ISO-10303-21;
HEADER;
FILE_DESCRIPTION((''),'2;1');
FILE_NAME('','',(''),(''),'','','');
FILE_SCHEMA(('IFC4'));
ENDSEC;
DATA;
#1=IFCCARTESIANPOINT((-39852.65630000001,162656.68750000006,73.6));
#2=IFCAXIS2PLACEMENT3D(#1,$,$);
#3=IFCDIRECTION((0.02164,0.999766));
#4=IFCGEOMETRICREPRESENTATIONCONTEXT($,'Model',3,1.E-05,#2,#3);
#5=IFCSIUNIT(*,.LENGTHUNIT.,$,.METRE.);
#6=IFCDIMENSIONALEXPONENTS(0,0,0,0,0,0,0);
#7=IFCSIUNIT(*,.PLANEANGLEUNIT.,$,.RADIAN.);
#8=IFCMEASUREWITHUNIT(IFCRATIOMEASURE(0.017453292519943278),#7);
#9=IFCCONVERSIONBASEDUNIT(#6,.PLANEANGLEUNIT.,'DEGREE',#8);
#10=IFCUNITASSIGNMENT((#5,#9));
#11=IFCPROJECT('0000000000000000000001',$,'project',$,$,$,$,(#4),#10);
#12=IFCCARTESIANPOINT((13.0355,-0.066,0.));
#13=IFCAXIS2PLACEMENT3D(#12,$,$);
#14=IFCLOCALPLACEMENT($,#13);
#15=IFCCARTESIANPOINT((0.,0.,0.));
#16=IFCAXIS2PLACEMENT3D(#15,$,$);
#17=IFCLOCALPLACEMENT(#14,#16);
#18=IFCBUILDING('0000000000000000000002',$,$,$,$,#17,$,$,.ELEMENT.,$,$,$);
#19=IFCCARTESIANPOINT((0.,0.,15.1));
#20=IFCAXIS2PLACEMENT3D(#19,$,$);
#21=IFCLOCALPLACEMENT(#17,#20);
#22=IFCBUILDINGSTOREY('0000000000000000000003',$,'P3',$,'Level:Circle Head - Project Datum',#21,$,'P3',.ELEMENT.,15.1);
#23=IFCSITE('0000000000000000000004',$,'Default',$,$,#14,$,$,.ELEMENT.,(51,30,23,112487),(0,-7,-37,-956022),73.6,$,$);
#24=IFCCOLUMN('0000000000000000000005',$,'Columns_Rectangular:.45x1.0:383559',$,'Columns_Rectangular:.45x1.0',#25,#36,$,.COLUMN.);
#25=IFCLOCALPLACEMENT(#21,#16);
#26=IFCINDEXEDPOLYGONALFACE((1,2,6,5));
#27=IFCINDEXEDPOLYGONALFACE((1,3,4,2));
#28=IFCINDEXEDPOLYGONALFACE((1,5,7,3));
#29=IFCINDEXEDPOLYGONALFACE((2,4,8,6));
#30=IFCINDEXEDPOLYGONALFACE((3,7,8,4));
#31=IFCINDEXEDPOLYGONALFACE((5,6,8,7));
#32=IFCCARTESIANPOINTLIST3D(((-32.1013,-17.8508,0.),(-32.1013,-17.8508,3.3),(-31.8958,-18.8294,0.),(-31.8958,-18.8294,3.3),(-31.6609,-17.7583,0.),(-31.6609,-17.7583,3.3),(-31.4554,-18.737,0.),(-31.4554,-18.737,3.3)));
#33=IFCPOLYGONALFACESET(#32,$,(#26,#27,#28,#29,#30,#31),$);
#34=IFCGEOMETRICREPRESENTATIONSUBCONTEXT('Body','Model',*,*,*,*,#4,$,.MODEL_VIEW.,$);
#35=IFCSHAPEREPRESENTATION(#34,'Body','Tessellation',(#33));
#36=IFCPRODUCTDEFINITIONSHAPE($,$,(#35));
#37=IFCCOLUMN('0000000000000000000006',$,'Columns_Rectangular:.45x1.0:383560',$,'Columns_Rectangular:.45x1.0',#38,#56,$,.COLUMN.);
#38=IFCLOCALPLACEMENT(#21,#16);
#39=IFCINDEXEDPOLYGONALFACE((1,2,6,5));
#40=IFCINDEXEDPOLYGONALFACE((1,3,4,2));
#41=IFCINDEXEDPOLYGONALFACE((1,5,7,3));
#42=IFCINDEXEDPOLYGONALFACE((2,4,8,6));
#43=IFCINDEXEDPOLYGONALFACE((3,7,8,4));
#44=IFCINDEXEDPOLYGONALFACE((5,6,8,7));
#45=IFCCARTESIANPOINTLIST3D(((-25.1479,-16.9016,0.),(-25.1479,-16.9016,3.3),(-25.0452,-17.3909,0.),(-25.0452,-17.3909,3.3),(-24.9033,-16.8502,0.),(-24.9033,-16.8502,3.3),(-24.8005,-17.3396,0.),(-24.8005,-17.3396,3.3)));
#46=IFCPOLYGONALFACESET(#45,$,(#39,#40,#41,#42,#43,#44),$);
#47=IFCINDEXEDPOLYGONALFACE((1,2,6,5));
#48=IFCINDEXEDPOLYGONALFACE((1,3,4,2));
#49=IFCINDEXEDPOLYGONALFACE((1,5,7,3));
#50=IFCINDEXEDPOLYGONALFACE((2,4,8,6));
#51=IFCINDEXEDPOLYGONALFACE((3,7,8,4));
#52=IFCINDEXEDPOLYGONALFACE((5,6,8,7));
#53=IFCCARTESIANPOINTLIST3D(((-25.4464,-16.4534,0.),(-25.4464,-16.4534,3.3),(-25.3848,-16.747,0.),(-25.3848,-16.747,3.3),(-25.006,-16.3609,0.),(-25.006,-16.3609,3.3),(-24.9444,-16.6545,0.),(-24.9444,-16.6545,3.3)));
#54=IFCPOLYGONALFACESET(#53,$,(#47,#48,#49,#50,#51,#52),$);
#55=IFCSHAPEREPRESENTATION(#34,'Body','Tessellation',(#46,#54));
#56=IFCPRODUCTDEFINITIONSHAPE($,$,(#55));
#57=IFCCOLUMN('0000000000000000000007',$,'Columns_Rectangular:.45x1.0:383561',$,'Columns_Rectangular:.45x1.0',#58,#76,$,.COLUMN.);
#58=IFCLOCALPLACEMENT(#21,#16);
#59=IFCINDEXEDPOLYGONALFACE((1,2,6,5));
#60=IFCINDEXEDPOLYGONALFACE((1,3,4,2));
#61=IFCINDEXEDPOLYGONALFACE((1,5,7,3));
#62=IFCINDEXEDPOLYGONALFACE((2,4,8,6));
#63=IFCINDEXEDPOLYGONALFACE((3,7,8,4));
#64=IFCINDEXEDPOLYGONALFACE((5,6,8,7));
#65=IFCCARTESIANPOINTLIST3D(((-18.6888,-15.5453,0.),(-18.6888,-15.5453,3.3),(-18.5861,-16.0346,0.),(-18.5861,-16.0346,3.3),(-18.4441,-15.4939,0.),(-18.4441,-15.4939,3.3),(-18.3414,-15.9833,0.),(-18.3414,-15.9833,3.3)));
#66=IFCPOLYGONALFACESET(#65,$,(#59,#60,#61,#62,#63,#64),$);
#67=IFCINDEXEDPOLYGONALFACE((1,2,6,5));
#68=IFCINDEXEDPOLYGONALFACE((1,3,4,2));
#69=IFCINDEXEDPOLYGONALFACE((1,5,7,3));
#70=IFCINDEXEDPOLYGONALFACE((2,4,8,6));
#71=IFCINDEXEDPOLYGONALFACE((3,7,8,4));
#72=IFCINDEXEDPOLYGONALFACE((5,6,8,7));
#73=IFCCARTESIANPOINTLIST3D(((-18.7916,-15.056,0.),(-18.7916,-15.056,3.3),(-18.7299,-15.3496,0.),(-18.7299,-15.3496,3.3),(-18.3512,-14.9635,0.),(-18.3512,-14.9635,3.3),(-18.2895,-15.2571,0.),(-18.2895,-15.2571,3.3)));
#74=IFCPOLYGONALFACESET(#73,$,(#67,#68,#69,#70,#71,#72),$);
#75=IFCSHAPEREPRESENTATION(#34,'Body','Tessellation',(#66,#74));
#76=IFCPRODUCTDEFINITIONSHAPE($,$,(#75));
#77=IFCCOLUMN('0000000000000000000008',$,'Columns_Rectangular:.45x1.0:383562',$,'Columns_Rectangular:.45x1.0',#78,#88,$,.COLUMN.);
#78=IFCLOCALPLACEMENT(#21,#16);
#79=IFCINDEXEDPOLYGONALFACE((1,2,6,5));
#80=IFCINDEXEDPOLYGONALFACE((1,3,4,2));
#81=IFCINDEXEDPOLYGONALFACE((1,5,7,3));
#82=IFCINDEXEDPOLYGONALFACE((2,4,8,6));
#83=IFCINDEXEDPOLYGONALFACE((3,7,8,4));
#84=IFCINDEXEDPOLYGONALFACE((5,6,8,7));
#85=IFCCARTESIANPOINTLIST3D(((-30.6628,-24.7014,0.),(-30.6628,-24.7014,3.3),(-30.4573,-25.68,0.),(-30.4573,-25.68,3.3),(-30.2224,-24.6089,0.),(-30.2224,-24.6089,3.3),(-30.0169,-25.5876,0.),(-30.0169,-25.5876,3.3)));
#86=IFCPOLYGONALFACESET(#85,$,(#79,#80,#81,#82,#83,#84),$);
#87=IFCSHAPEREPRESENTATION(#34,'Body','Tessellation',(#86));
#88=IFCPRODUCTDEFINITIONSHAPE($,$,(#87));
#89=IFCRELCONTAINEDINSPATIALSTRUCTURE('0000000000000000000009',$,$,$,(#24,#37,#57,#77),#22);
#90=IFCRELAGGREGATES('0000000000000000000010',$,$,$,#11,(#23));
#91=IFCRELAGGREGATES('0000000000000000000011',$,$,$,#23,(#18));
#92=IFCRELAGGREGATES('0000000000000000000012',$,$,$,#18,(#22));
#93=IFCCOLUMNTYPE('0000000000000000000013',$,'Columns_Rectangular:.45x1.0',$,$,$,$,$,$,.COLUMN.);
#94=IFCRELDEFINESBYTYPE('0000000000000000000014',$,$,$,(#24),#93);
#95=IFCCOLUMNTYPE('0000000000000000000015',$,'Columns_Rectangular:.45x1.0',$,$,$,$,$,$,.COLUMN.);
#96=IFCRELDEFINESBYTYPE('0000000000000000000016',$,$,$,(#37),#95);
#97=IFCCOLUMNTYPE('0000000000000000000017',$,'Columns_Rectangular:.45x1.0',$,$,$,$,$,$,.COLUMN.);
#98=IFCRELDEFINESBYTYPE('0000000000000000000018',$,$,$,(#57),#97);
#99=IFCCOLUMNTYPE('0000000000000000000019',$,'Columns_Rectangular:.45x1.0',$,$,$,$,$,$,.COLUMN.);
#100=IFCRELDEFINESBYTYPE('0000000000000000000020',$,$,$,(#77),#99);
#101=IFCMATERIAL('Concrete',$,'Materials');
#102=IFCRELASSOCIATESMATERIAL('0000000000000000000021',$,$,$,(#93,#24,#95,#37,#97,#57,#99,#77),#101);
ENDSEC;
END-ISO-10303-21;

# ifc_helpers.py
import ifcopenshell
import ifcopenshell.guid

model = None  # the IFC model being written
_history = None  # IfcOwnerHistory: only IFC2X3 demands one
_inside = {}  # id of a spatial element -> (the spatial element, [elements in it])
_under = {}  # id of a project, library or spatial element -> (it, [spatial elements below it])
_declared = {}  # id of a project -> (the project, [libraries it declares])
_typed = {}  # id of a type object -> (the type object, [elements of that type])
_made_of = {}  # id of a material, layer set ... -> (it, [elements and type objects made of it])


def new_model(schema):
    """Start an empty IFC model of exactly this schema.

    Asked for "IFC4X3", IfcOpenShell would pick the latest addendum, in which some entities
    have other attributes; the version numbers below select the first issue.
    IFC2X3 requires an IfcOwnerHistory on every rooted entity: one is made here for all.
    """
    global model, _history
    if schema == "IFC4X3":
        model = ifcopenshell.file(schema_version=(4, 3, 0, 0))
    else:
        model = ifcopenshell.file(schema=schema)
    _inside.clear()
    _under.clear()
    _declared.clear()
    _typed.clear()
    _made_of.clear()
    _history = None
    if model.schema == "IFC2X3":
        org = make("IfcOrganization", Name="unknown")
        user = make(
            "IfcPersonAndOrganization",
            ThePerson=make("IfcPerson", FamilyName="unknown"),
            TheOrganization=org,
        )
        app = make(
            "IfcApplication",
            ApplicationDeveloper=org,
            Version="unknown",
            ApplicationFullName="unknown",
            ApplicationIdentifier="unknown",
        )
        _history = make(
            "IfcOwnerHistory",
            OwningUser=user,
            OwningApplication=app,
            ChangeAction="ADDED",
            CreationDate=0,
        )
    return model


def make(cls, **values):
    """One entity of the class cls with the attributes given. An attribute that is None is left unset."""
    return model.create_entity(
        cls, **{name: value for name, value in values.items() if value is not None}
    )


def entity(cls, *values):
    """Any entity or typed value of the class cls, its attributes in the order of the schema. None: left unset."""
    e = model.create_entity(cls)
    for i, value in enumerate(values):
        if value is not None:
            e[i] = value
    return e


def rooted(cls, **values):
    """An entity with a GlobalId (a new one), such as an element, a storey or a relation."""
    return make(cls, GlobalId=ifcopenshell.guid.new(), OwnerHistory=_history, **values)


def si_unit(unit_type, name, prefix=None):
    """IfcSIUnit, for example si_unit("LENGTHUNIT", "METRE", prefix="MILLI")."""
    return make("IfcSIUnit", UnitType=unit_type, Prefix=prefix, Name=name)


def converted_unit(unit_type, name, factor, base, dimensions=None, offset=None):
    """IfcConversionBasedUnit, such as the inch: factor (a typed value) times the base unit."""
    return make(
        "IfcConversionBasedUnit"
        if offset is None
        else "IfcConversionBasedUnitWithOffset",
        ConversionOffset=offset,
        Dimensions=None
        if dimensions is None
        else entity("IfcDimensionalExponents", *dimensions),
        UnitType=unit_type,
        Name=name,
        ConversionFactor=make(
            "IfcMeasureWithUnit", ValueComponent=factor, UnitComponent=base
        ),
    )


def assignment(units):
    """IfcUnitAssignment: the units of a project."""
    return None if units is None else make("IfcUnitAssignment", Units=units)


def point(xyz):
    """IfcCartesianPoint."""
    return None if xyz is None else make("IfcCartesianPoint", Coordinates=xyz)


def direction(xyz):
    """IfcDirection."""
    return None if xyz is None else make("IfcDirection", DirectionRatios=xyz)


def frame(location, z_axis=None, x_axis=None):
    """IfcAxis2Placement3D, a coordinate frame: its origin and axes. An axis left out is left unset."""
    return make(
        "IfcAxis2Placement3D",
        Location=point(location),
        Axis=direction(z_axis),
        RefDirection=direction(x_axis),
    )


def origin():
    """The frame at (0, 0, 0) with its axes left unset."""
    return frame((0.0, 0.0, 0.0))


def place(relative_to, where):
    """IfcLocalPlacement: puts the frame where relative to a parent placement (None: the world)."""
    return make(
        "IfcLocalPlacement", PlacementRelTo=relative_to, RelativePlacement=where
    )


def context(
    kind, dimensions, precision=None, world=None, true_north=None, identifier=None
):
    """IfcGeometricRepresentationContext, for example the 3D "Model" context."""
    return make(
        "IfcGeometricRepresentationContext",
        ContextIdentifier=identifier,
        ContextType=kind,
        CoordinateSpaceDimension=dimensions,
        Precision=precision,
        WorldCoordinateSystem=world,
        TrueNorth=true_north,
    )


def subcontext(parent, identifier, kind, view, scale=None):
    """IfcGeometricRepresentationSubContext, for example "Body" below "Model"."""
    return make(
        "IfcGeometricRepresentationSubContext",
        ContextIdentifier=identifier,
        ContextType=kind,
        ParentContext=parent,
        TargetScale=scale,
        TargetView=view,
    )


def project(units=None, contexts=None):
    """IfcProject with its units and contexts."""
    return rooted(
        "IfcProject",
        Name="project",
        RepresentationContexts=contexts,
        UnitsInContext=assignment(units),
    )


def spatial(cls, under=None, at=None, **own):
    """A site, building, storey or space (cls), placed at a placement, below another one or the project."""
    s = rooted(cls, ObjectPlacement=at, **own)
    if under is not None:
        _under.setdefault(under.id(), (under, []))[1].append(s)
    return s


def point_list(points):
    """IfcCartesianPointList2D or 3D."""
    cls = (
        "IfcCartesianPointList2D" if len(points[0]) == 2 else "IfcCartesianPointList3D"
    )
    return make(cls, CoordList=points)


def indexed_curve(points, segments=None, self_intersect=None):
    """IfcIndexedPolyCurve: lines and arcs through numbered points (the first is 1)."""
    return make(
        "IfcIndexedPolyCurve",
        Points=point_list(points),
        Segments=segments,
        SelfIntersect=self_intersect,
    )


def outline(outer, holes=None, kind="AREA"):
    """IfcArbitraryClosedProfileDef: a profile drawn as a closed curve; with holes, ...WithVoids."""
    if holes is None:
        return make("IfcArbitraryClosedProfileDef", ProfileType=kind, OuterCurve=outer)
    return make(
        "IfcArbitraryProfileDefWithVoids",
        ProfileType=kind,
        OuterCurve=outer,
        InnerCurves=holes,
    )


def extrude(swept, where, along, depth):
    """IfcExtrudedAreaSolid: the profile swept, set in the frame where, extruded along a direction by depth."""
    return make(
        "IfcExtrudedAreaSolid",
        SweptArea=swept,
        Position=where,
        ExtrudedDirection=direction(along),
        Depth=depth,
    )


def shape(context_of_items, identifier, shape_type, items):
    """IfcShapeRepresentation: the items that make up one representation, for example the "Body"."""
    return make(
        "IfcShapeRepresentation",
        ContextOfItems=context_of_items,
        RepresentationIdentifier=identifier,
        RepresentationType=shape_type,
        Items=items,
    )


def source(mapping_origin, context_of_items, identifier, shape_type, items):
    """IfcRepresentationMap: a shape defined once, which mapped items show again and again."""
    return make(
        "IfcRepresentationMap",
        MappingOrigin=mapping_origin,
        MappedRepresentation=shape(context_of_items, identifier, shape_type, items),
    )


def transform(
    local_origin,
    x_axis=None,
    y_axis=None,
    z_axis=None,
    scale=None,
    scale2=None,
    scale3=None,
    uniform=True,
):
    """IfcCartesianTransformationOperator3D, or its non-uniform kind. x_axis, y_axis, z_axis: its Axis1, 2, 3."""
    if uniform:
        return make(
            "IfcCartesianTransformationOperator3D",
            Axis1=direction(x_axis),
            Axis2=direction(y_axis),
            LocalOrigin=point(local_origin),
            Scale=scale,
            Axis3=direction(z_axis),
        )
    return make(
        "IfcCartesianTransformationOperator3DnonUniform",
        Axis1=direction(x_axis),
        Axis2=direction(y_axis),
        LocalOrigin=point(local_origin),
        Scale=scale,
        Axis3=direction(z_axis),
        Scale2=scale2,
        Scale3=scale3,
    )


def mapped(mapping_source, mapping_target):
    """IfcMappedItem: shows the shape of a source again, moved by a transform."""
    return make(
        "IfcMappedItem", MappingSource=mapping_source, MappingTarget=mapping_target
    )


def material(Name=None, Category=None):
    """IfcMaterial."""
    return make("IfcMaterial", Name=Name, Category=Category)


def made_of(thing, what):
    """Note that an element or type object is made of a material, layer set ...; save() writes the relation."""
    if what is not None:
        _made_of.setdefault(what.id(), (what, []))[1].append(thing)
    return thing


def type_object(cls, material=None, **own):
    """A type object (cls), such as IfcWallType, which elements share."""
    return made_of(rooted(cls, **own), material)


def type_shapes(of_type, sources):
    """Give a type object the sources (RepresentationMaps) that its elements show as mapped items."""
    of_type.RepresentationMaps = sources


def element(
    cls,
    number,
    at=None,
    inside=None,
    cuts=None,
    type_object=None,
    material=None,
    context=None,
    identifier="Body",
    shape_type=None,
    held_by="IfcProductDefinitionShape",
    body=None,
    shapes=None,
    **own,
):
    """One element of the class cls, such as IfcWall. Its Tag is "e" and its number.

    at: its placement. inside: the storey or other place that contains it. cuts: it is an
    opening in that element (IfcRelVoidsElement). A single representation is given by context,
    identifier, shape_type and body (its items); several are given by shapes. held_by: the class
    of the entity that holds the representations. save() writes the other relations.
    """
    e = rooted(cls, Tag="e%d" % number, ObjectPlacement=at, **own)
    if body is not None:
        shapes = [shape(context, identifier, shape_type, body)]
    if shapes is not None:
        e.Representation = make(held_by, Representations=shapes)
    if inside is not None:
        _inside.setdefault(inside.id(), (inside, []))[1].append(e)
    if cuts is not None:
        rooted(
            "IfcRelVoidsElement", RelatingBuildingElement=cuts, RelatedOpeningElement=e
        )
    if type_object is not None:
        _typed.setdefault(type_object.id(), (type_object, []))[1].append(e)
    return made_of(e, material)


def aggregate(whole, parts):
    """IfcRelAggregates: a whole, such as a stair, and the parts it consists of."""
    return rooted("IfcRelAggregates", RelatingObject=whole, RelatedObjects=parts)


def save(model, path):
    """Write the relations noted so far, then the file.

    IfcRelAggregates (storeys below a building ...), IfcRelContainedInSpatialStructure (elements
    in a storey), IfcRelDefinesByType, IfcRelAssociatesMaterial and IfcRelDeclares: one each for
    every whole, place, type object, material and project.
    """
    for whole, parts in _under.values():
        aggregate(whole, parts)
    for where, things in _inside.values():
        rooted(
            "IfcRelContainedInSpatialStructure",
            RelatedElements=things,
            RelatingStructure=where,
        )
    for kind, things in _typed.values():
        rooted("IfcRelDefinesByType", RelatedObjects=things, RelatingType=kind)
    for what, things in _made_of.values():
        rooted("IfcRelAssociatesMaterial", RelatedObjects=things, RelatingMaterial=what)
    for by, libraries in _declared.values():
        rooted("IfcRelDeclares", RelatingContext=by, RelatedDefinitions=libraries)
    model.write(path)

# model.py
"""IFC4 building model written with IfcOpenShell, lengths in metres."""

from ifc_helpers import new_model, entity, si_unit, converted_unit, direction, frame, origin, place, context, subcontext, project, spatial, indexed_curve, outline, extrude, source, transform, mapped, material, type_object, type_shapes, element, save


model = new_model("IFC4")

# Units and contexts
model_context = context("Model", 3, precision=1e-05, world=frame((-39852.65630000001, 162656.68750000006, 73.6)), true_north=direction((0.02164, 0.999766)))
body_context = subcontext(model_context, "Body", "Model", "MODEL_VIEW")
ifc_project = project(units=[si_unit("LENGTHUNIT", "METRE"), converted_unit("PLANEANGLEUNIT", "DEGREE", entity("IfcRatioMeasure", 0.017453292519943278), si_unit("PLANEANGLEUNIT", "RADIAN"), dimensions=[0, 0, 0, 0, 0, 0, 0])], contexts=[model_context])

# Site, building, storey
site_placement = place(None, frame((13.0355, -0.066, 0.0)))
site = spatial("IfcSite", under=ifc_project, at=site_placement, Name="Default", CompositionType="ELEMENT", RefLatitude=(51, 30, 23, 112487), RefLongitude=(0, -7, -37, -956022), RefElevation=73.6)
building_placement = place(site_placement, origin())
building = spatial("IfcBuilding", under=site, at=building_placement, CompositionType="ELEMENT")
storey_placement = place(building_placement, frame((0.0, 0.0, 15.1)))
storey = spatial("IfcBuildingStorey", under=building, at=storey_placement, Name="P3", ObjectType="Level:Circle Head - Project Datum", LongName="P3", CompositionType="ELEMENT", Elevation=15.1)

# Columns
ifc_material = material(Name="Concrete", Category="Materials")
column_type_1 = type_object("IfcColumnType", Name="Columns_Rectangular:.45x1.0", PredefinedType="COLUMN", material=ifc_material)
shared_shape_1 = source(origin(), body_context, "Body", "SweptSolid", [
    extrude(outline(indexed_curve([(-0.5, -0.225), (0.5, -0.225), (0.5, 0.225), (-0.5, 0.225), (-0.5, -0.225)], self_intersect=False)), frame((-31.7784, -18.2939, 15.1), z_axis=(0.0, 0.0, 1.0), x_axis=(-0.2055, 0.978657, 0.0)), (0.0, 0.0, 1.0), 3.3),
])
type_shapes(column_type_1, [shared_shape_1])
column_1_placement = place(storey_placement, frame((0.0, 0.0, -15.1)))
element("IfcColumn", 1, at=column_1_placement, inside=storey, type_object=column_type_1, material=ifc_material, Name="Columns_Rectangular:.45x1.0:383559", ObjectType="Columns_Rectangular:.45x1.0", PredefinedType="COLUMN", context=body_context, shape_type="MappedRepresentation", body=[
    mapped(shared_shape_1, transform((0.0, 0.0, 0.0), scale=1.0)),
])
column_type_2 = type_object("IfcColumnType", Name="Columns_Rectangular:.45x1.0", PredefinedType="COLUMN", material=ifc_material)
shared_shape_2 = source(origin(), body_context, "Body", "SweptSolid", [
    extrude(outline(indexed_curve([(-0.25, -0.125), (0.25, -0.125), (0.25, 0.125), (-0.25, 0.125), (-0.25, -0.125)], self_intersect=False)), frame((-24.9742, -17.1206, 15.1), z_axis=(0.0, 0.0, 1.0), x_axis=(-0.2055, 0.978657, 0.0)), (0.0, 0.0, 1.0), 3.3),
    extrude(outline(indexed_curve([(-0.225, -0.15), (0.225, -0.15), (0.225, 0.15), (-0.225, 0.15), (-0.225, -0.15)], self_intersect=False)), frame((-25.1954, -16.5539, 15.1), z_axis=(0.0, 0.0, 1.0), x_axis=(-0.978657, -0.2055, 0.0)), (0.0, 0.0, 1.0), 3.3),
])
type_shapes(column_type_2, [shared_shape_2])
column_2_placement = place(storey_placement, frame((0.0, 0.0, -15.1)))
element("IfcColumn", 2, at=column_2_placement, inside=storey, type_object=column_type_2, material=ifc_material, Name="Columns_Rectangular:.45x1.0:383560", ObjectType="Columns_Rectangular:.45x1.0", PredefinedType="COLUMN", context=body_context, shape_type="MappedRepresentation", body=[
    mapped(shared_shape_2, transform((0.0, 0.0, 0.0), scale=1.0)),
])
column_type_3 = type_object("IfcColumnType", Name="Columns_Rectangular:.45x1.0", PredefinedType="COLUMN", material=ifc_material)
shared_shape_3 = source(origin(), body_context, "Body", "SweptSolid", [
    extrude(outline(indexed_curve([(-0.25, -0.125), (0.25, -0.125), (0.25, 0.125), (-0.25, 0.125), (-0.25, -0.125)], self_intersect=False)), frame((-18.5151, -15.7643, 15.1), z_axis=(0.0, 0.0, 1.0), x_axis=(-0.2055, 0.978657, 0.0)), (0.0, 0.0, 1.0), 3.3),
    extrude(outline(indexed_curve([(-0.225, -0.15), (0.225, -0.15), (0.225, 0.15), (-0.225, 0.15), (-0.225, -0.15)], self_intersect=False)), frame((-18.5405, -15.1565, 15.1), z_axis=(0.0, 0.0, 1.0), x_axis=(-0.978657, -0.2055, 0.0)), (0.0, 0.0, 1.0), 3.3),
])
type_shapes(column_type_3, [shared_shape_3])
column_3_placement = place(storey_placement, frame((0.0, 0.0, -15.1)))
element("IfcColumn", 3, at=column_3_placement, inside=storey, type_object=column_type_3, material=ifc_material, Name="Columns_Rectangular:.45x1.0:383561", ObjectType="Columns_Rectangular:.45x1.0", PredefinedType="COLUMN", context=body_context, shape_type="MappedRepresentation", body=[
    mapped(shared_shape_3, transform((0.0, 0.0, 0.0), scale=1.0)),
])
column_type_4 = type_object("IfcColumnType", Name="Columns_Rectangular:.45x1.0", PredefinedType="COLUMN", material=ifc_material)
shared_shape_4 = source(origin(), body_context, "Body", "SweptSolid", [
    extrude(outline(indexed_curve([(-0.5, -0.225), (0.5, -0.225), (0.5, 0.225), (-0.5, 0.225), (-0.5, -0.225)], self_intersect=False)), frame((-30.3399, -25.1445, 15.1), z_axis=(0.0, 0.0, 1.0), x_axis=(-0.2055, 0.978657, 0.0)), (0.0, 0.0, 1.0), 3.3),
])
type_shapes(column_type_4, [shared_shape_4])
column_4_placement = place(storey_placement, frame((0.0, 0.0, -15.1)))
element("IfcColumn", 4, at=column_4_placement, inside=storey, type_object=column_type_4, material=ifc_material, Name="Columns_Rectangular:.45x1.0:383562", ObjectType="Columns_Rectangular:.45x1.0", PredefinedType="COLUMN", context=body_context, shape_type="MappedRepresentation", body=[
    mapped(shared_shape_4, transform((0.0, 0.0, 0.0), scale=1.0)),
])

save(model, "model.ifc")
